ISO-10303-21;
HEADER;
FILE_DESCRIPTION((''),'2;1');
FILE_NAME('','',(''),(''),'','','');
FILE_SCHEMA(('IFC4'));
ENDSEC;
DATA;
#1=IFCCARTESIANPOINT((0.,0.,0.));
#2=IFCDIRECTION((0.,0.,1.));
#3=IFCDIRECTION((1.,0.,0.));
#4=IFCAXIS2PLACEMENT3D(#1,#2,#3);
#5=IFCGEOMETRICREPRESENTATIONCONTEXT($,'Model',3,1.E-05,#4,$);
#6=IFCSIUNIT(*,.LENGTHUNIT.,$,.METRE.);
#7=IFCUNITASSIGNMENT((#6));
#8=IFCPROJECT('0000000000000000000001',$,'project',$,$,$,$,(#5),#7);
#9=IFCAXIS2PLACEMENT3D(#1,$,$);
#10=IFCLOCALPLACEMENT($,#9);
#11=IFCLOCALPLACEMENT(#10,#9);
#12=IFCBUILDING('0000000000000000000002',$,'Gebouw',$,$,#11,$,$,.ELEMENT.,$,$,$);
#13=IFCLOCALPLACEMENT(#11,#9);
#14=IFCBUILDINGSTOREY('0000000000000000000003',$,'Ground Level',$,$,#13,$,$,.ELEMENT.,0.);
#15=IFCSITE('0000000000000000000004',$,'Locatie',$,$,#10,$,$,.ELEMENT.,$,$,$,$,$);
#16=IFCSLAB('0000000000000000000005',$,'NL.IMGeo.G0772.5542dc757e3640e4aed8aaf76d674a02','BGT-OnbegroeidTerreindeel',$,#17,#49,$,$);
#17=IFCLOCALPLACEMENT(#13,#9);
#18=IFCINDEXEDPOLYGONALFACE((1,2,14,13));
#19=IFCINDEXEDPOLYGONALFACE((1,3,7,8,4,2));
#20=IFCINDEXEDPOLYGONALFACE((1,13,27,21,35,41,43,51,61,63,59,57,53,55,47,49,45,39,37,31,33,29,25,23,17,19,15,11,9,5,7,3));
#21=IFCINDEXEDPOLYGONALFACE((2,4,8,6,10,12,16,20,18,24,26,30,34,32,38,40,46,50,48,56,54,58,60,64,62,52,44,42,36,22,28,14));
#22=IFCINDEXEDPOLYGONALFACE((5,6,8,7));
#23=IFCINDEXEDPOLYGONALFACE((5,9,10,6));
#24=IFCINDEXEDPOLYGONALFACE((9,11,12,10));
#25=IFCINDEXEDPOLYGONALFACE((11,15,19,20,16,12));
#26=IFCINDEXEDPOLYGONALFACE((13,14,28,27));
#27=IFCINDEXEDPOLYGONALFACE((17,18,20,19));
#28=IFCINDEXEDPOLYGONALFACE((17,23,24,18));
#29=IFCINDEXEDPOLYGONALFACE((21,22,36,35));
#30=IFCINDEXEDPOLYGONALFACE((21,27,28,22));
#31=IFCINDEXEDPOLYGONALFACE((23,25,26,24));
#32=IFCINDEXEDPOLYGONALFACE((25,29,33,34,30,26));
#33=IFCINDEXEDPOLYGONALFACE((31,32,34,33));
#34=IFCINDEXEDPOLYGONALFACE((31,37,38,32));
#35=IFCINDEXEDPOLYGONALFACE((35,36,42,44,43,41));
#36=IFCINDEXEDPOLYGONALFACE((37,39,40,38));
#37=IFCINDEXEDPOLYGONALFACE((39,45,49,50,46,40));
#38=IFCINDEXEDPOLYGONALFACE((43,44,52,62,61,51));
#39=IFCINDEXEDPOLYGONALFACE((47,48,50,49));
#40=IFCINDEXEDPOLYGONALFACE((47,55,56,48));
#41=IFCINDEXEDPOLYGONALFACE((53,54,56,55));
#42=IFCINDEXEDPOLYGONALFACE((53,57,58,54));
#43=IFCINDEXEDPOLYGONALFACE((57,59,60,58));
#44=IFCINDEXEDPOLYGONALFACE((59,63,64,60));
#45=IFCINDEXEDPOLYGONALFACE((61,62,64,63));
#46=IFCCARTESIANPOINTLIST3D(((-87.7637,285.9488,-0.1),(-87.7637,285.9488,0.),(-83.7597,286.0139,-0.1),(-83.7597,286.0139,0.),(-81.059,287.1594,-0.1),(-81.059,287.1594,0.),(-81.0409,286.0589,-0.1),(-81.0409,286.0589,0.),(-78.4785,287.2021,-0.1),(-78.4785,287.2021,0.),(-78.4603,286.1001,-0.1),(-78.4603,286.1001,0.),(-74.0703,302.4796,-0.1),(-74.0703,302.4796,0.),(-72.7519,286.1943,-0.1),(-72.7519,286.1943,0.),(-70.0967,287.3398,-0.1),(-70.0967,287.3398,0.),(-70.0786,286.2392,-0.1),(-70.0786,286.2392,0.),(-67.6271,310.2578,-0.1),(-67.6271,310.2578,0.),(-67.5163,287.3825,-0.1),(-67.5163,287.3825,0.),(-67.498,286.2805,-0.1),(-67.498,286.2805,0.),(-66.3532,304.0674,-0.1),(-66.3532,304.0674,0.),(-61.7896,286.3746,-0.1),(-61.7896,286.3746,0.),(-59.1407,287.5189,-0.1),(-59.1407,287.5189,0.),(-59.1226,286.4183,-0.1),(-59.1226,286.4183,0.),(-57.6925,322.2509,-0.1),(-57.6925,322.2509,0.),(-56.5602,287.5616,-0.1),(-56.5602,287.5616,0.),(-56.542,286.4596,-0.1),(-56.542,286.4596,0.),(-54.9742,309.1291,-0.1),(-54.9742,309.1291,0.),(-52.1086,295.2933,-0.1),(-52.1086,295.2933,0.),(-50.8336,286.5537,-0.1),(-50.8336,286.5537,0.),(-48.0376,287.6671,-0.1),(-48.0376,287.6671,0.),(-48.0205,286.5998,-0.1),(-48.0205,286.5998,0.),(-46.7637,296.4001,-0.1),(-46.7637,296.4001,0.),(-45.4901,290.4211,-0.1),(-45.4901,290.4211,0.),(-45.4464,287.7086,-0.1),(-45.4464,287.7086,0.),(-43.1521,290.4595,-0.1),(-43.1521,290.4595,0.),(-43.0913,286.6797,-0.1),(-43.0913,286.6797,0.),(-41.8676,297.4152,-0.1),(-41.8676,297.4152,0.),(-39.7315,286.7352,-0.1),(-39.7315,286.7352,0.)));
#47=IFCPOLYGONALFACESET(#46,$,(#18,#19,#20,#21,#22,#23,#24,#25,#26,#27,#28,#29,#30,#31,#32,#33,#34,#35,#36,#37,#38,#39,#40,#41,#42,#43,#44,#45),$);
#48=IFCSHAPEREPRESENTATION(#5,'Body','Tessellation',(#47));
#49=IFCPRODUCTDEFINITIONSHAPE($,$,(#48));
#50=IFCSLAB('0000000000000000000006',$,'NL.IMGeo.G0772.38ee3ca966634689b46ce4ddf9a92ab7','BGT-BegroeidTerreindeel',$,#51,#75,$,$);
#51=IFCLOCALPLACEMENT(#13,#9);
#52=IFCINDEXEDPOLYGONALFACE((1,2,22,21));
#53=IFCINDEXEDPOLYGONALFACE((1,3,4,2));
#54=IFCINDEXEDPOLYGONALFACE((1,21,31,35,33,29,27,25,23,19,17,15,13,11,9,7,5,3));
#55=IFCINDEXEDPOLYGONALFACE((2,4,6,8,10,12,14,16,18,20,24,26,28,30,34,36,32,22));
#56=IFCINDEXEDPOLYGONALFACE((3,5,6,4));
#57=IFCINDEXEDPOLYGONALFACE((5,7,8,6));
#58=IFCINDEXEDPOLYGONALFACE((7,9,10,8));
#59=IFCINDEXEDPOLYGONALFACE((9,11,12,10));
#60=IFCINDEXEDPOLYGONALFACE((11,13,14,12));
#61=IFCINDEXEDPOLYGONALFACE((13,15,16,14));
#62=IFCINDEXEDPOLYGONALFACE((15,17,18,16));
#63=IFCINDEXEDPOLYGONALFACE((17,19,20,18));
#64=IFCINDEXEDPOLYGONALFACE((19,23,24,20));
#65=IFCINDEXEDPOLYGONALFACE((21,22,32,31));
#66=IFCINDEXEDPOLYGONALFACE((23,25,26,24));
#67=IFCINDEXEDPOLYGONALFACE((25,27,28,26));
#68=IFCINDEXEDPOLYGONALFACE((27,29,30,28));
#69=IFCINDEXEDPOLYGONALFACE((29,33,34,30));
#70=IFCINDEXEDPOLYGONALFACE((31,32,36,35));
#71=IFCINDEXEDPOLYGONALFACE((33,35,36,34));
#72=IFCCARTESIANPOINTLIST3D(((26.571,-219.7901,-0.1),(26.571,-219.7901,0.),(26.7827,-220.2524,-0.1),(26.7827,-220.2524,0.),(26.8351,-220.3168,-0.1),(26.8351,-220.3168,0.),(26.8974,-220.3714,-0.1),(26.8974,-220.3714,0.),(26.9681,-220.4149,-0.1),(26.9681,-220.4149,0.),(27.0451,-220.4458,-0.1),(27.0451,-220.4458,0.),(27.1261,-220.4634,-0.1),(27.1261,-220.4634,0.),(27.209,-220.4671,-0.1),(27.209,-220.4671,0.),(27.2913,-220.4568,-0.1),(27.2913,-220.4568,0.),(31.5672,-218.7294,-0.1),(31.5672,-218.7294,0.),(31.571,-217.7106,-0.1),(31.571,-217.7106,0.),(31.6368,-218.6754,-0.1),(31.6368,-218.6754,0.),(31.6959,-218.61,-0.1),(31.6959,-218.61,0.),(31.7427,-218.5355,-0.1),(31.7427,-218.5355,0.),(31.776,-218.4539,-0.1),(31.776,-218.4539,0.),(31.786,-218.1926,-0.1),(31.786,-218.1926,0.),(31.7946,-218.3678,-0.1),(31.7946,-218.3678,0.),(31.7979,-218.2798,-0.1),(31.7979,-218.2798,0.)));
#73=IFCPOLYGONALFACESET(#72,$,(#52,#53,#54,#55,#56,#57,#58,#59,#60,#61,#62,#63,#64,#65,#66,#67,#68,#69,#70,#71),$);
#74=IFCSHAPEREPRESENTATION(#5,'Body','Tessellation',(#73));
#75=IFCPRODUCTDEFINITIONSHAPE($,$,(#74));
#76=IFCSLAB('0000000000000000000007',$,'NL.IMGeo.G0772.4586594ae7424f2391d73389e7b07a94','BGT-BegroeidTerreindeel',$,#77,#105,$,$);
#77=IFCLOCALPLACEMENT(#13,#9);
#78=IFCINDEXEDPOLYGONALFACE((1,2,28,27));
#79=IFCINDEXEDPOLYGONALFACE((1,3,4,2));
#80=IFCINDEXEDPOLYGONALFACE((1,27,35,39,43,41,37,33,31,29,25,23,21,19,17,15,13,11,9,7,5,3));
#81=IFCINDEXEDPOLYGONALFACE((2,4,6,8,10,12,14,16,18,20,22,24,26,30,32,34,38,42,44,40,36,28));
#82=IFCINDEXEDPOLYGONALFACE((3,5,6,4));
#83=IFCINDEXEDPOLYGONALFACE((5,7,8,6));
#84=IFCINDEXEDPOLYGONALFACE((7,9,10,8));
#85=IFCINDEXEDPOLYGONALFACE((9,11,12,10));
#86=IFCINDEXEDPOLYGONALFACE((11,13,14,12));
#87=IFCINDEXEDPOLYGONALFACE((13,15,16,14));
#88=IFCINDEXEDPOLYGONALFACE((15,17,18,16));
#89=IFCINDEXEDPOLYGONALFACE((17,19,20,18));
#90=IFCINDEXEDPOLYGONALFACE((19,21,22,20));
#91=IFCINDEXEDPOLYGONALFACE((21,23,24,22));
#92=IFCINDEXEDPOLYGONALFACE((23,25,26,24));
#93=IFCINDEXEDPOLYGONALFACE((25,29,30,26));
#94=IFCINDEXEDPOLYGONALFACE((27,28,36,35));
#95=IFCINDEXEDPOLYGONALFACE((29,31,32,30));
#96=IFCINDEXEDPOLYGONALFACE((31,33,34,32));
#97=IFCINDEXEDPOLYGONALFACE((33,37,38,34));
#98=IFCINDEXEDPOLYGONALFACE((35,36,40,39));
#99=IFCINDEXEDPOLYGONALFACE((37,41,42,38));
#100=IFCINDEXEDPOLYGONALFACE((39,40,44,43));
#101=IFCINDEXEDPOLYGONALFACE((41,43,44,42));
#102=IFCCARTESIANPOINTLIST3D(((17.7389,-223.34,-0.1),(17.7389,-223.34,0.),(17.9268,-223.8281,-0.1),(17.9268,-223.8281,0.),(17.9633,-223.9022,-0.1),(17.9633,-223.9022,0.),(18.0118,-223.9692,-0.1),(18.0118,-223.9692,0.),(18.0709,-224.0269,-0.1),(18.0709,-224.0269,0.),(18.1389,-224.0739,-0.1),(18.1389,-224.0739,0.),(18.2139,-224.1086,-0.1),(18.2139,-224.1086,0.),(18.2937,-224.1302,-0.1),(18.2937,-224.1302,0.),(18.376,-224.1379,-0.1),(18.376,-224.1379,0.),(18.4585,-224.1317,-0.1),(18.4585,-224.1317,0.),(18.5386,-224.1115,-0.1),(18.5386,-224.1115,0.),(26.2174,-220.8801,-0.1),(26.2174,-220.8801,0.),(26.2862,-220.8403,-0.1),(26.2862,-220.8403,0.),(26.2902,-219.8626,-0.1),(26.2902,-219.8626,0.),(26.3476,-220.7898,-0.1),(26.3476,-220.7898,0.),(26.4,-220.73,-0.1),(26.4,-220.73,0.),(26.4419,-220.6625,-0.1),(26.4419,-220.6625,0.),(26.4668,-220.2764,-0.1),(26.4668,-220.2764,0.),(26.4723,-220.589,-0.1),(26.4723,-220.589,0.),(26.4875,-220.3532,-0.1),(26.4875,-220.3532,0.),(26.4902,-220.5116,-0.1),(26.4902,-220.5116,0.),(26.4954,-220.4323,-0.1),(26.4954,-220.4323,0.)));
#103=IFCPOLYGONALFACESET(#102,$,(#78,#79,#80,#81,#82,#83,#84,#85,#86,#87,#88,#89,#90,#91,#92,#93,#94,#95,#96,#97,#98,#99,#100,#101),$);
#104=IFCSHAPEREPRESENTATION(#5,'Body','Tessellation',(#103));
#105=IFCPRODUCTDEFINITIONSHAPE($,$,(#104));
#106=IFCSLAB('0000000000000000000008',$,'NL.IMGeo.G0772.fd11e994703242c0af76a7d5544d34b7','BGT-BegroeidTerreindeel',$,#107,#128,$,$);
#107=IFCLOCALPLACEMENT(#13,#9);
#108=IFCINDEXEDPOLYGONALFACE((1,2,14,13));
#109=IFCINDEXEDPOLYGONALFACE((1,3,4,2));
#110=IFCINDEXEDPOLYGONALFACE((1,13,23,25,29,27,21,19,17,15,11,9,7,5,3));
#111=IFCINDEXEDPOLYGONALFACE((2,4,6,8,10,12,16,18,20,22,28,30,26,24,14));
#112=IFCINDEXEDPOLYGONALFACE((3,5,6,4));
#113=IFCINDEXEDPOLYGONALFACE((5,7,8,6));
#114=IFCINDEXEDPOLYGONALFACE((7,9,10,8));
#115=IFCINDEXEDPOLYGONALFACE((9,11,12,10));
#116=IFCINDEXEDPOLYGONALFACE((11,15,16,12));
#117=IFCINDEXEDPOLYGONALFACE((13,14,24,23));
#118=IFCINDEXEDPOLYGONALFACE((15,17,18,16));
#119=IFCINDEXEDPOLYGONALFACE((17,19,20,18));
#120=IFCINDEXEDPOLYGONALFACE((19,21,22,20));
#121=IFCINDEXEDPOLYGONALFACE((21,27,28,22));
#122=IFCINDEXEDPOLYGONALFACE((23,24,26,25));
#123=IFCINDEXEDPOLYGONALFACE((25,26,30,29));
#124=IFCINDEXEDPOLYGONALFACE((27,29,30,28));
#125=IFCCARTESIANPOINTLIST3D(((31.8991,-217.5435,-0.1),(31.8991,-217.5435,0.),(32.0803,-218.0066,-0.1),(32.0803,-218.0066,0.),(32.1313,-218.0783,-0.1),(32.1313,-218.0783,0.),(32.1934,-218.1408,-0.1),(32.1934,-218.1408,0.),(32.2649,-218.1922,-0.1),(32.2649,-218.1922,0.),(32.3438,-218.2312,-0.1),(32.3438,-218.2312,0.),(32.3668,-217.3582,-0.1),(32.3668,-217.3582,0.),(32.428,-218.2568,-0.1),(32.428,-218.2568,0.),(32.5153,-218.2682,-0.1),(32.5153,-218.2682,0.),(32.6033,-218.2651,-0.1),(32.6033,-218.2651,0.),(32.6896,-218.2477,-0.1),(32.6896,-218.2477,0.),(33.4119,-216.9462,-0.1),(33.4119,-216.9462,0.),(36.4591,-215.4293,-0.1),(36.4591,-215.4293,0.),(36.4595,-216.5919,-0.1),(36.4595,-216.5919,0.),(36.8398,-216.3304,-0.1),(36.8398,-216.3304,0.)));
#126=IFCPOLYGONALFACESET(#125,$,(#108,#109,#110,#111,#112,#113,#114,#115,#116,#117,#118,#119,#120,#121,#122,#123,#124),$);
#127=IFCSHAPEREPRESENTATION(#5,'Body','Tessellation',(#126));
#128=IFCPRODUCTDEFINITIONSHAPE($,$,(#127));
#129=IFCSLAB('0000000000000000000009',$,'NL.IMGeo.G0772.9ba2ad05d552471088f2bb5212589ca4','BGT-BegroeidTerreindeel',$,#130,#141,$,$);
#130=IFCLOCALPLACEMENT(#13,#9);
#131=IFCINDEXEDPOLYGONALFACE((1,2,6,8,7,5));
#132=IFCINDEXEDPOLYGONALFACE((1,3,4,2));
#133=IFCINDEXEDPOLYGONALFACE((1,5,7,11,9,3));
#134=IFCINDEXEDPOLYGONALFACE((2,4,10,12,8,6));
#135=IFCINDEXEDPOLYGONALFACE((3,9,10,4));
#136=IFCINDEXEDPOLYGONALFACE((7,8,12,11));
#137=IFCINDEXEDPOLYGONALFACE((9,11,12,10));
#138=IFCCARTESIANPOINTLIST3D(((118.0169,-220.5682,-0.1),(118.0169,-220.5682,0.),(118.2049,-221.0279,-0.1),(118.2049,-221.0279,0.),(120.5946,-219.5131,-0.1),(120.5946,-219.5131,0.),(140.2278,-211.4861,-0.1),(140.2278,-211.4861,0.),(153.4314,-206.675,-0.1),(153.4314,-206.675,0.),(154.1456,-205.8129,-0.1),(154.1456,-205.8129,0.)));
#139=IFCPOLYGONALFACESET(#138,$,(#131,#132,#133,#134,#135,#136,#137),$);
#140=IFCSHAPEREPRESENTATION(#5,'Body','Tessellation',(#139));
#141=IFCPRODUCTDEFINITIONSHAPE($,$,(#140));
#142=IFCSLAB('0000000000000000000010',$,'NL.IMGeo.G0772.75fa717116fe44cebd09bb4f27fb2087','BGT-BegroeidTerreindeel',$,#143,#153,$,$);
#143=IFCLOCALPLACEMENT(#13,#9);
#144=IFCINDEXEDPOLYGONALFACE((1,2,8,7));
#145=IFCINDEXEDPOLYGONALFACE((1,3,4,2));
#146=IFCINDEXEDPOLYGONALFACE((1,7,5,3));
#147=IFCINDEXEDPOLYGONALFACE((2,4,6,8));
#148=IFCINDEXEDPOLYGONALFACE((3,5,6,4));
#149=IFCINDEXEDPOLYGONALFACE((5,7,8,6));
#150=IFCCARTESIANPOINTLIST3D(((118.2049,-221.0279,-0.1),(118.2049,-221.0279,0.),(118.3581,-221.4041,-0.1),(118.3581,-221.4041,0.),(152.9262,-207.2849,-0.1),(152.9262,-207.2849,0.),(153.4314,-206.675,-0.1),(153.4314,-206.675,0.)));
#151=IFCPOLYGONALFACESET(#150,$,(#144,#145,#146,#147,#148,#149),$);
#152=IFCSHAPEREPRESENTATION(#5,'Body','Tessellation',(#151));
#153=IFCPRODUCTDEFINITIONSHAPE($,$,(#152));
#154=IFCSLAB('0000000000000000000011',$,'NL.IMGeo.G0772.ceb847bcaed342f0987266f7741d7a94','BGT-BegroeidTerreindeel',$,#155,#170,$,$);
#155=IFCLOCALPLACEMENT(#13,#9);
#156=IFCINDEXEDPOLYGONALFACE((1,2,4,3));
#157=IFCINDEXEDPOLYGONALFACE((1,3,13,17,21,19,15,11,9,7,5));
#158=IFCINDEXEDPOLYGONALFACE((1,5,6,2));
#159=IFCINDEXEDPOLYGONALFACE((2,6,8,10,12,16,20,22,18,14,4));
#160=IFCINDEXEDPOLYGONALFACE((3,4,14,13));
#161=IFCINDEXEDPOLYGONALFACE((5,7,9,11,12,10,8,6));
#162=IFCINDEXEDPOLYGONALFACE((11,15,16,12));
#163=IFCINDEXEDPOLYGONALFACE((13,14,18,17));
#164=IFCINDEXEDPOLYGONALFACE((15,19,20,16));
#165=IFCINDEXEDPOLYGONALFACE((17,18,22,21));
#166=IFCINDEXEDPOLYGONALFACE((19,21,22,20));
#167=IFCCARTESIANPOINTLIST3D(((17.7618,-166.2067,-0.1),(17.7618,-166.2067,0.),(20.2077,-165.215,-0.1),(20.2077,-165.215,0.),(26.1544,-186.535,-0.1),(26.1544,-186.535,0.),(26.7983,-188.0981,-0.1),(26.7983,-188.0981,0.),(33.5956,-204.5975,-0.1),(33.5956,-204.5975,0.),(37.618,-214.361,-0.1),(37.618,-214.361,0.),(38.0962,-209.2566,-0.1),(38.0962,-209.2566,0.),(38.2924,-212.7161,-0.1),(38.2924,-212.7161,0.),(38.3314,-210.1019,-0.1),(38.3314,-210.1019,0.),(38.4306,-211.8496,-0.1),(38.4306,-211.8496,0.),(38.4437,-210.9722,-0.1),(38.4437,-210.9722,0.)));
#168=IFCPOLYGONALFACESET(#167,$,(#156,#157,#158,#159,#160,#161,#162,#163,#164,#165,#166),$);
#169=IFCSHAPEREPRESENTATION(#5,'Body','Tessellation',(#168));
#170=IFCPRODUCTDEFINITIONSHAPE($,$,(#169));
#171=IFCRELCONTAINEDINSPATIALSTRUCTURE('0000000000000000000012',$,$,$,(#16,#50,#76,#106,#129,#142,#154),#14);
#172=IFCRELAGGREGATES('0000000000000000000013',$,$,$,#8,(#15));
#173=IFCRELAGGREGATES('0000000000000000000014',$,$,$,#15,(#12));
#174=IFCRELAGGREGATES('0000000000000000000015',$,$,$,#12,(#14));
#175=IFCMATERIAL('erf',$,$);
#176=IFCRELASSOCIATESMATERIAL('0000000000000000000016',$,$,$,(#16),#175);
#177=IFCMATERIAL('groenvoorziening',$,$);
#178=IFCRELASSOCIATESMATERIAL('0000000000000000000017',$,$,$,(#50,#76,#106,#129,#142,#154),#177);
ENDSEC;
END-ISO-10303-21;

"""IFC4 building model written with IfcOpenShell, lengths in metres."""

from ifc_helpers import new_model, si_unit, frame, origin, origin_with_axes, place, context, project, spatial, polyline, outline, extrude, material, element, save


model = new_model("IFC4")

# Units and contexts
model_context = context("Model", 3, precision=1e-05, world=origin_with_axes())
ifc_project = project(units=[si_unit("LENGTHUNIT", "METRE")], contexts=[model_context])

# Site, building, storey
site_placement = place(None, origin())
site = spatial("IfcSite", under=ifc_project, at=site_placement, Name="Locatie", CompositionType="ELEMENT")
building_placement = place(site_placement, origin())
building = spatial("IfcBuilding", under=site, at=building_placement, Name="Gebouw", CompositionType="ELEMENT")
storey_placement = place(building_placement, origin())
storey = spatial("IfcBuildingStorey", under=building, at=storey_placement, Name="Ground Level", CompositionType="ELEMENT", Elevation=0.0)

# Slabs
ifc_material_1 = material(Name="erf")
slab_1_placement = place(storey_placement, origin())
element("IfcSlab", 1, at=slab_1_placement, inside=storey, material=ifc_material_1, Name="NL.IMGeo.G0772.5542dc757e3640e4aed8aaf76d674a02", Description="BGT-OnbegroeidTerreindeel", context=model_context, shape_type="SweptSolid", body=[
    extrude(outline(polyline([(-54.9742, 309.1291), (-52.1086, 295.2933), (-46.7637, 296.4001), (-41.8676, 297.4152), (-39.7315, 286.7352), (-43.0913, 286.6797), (-43.1521, 290.4595), (-45.4901, 290.4211), (-45.4464, 287.7086), (-48.0376, 287.6671), (-48.0205, 286.5998), (-50.8336, 286.5537), (-56.542, 286.4596), (-56.5602, 287.5616), (-59.1407, 287.5189), (-59.1226, 286.4183), (-61.7896, 286.3746), (-67.498, 286.2805), (-67.5163, 287.3825), (-70.0967, 287.3398), (-70.0786, 286.2392), (-72.7519, 286.1943), (-78.4603, 286.1001), (-78.4785, 287.2021), (-81.059, 287.1594), (-81.0409, 286.0589), (-83.7597, 286.0139), (-87.7637, 285.9488), (-74.0703, 302.4796), (-66.3532, 304.0674), (-67.6271, 310.2578), (-57.6925, 322.2509), (-54.9742, 309.1291)])), frame((0.0, 0.0, -0.1), z_axis=(0.0, 0.0, 1.0), x_axis=(1.0, 0.0, 0.0)), (0.0, 0.0, 1.0), 0.1),
])
ifc_material_2 = material(Name="groenvoorziening")
slab_2_placement = place(storey_placement, origin())
element("IfcSlab", 2, at=slab_2_placement, inside=storey, material=ifc_material_2, Name="NL.IMGeo.G0772.38ee3ca966634689b46ce4ddf9a92ab7", Description="BGT-BegroeidTerreindeel", context=model_context, shape_type="SweptSolid", body=[
    extrude(outline(polyline([(27.2913, -220.4568), (27.209, -220.4671), (27.1261, -220.4634), (27.0451, -220.4458), (26.9681, -220.4149), (26.8974, -220.3714), (26.8351, -220.3168), (26.7827, -220.2524), (26.571, -219.7901), (31.571, -217.7106), (31.786, -218.1926), (31.7979, -218.2798), (31.7946, -218.3678), (31.776, -218.4539), (31.7427, -218.5355), (31.6959, -218.61), (31.6368, -218.6754), (31.5672, -218.7294), (27.2913, -220.4568)])), frame((0.0, 0.0, -0.1), z_axis=(0.0, 0.0, 1.0), x_axis=(1.0, 0.0, 0.0)), (0.0, 0.0, 1.0), 0.1),
])
slab_3_placement = place(storey_placement, origin())
element("IfcSlab", 3, at=slab_3_placement, inside=storey, material=ifc_material_2, Name="NL.IMGeo.G0772.4586594ae7424f2391d73389e7b07a94", Description="BGT-BegroeidTerreindeel", context=model_context, shape_type="SweptSolid", body=[
    extrude(outline(polyline([(26.4875, -220.3532), (26.4954, -220.4323), (26.4902, -220.5116), (26.4723, -220.589), (26.4419, -220.6625), (26.4, -220.73), (26.3476, -220.7898), (26.2862, -220.8403), (26.2174, -220.8801), (18.5386, -224.1115), (18.4585, -224.1317), (18.376, -224.1379), (18.2937, -224.1302), (18.2139, -224.1086), (18.1389, -224.0739), (18.0709, -224.0269), (18.0118, -223.9692), (17.9633, -223.9022), (17.9268, -223.8281), (17.7389, -223.34), (26.2902, -219.8626), (26.4668, -220.2764), (26.4875, -220.3532)])), frame((0.0, 0.0, -0.1), z_axis=(0.0, 0.0, 1.0), x_axis=(1.0, 0.0, 0.0)), (0.0, 0.0, 1.0), 0.1),
])
slab_4_placement = place(storey_placement, origin())
element("IfcSlab", 4, at=slab_4_placement, inside=storey, material=ifc_material_2, Name="NL.IMGeo.G0772.fd11e994703242c0af76a7d5544d34b7", Description="BGT-BegroeidTerreindeel", context=model_context, shape_type="SweptSolid", body=[
    extrude(outline(polyline([(31.8991, -217.5435), (32.3668, -217.3582), (33.4119, -216.9462), (36.4591, -215.4293), (36.8398, -216.3304), (36.4595, -216.5919), (32.6896, -218.2477), (32.6033, -218.2651), (32.5153, -218.2682), (32.428, -218.2568), (32.3438, -218.2312), (32.2649, -218.1922), (32.1934, -218.1408), (32.1313, -218.0783), (32.0803, -218.0066), (31.8991, -217.5435)])), frame((0.0, 0.0, -0.1), z_axis=(0.0, 0.0, 1.0), x_axis=(1.0, 0.0, 0.0)), (0.0, 0.0, 1.0), 0.1),
])
slab_5_placement = place(storey_placement, origin())
element("IfcSlab", 5, at=slab_5_placement, inside=storey, material=ifc_material_2, Name="NL.IMGeo.G0772.9ba2ad05d552471088f2bb5212589ca4", Description="BGT-BegroeidTerreindeel", context=model_context, shape_type="SweptSolid", body=[
    extrude(outline(polyline([(118.2049, -221.0279), (118.0169, -220.5682), (120.5946, -219.5131), (140.2278, -211.4861), (154.1456, -205.8129), (153.4314, -206.675), (118.2049, -221.0279)])), frame((0.0, 0.0, -0.1), z_axis=(0.0, 0.0, 1.0), x_axis=(1.0, 0.0, 0.0)), (0.0, 0.0, 1.0), 0.1),
])
slab_6_placement = place(storey_placement, origin())
element("IfcSlab", 6, at=slab_6_placement, inside=storey, material=ifc_material_2, Name="NL.IMGeo.G0772.75fa717116fe44cebd09bb4f27fb2087", Description="BGT-BegroeidTerreindeel", context=model_context, shape_type="SweptSolid", body=[
    extrude(outline(polyline([(118.3581, -221.4041), (118.2049, -221.0279), (153.4314, -206.675), (152.9262, -207.2849), (118.3581, -221.4041)])), frame((0.0, 0.0, -0.1), z_axis=(0.0, 0.0, 1.0), x_axis=(1.0, 0.0, 0.0)), (0.0, 0.0, 1.0), 0.1),
])
slab_7_placement = place(storey_placement, origin())
element("IfcSlab", 7, at=slab_7_placement, inside=storey, material=ifc_material_2, Name="NL.IMGeo.G0772.ceb847bcaed342f0987266f7741d7a94", Description="BGT-BegroeidTerreindeel", context=model_context, shape_type="SweptSolid", body=[
    extrude(outline(polyline([(38.0962, -209.2566), (38.3314, -210.1019), (38.4437, -210.9722), (38.4306, -211.8496), (38.2924, -212.7161), (37.618, -214.361), (33.5956, -204.5975), (26.7983, -188.0981), (26.1544, -186.535), (17.7618, -166.2067), (20.2077, -165.215), (38.0962, -209.2566)])), frame((0.0, 0.0, -0.1), z_axis=(0.0, 0.0, 1.0), x_axis=(1.0, 0.0, 0.0)), (0.0, 0.0, 1.0), 0.1),
])

save(model, "model.ifc")
